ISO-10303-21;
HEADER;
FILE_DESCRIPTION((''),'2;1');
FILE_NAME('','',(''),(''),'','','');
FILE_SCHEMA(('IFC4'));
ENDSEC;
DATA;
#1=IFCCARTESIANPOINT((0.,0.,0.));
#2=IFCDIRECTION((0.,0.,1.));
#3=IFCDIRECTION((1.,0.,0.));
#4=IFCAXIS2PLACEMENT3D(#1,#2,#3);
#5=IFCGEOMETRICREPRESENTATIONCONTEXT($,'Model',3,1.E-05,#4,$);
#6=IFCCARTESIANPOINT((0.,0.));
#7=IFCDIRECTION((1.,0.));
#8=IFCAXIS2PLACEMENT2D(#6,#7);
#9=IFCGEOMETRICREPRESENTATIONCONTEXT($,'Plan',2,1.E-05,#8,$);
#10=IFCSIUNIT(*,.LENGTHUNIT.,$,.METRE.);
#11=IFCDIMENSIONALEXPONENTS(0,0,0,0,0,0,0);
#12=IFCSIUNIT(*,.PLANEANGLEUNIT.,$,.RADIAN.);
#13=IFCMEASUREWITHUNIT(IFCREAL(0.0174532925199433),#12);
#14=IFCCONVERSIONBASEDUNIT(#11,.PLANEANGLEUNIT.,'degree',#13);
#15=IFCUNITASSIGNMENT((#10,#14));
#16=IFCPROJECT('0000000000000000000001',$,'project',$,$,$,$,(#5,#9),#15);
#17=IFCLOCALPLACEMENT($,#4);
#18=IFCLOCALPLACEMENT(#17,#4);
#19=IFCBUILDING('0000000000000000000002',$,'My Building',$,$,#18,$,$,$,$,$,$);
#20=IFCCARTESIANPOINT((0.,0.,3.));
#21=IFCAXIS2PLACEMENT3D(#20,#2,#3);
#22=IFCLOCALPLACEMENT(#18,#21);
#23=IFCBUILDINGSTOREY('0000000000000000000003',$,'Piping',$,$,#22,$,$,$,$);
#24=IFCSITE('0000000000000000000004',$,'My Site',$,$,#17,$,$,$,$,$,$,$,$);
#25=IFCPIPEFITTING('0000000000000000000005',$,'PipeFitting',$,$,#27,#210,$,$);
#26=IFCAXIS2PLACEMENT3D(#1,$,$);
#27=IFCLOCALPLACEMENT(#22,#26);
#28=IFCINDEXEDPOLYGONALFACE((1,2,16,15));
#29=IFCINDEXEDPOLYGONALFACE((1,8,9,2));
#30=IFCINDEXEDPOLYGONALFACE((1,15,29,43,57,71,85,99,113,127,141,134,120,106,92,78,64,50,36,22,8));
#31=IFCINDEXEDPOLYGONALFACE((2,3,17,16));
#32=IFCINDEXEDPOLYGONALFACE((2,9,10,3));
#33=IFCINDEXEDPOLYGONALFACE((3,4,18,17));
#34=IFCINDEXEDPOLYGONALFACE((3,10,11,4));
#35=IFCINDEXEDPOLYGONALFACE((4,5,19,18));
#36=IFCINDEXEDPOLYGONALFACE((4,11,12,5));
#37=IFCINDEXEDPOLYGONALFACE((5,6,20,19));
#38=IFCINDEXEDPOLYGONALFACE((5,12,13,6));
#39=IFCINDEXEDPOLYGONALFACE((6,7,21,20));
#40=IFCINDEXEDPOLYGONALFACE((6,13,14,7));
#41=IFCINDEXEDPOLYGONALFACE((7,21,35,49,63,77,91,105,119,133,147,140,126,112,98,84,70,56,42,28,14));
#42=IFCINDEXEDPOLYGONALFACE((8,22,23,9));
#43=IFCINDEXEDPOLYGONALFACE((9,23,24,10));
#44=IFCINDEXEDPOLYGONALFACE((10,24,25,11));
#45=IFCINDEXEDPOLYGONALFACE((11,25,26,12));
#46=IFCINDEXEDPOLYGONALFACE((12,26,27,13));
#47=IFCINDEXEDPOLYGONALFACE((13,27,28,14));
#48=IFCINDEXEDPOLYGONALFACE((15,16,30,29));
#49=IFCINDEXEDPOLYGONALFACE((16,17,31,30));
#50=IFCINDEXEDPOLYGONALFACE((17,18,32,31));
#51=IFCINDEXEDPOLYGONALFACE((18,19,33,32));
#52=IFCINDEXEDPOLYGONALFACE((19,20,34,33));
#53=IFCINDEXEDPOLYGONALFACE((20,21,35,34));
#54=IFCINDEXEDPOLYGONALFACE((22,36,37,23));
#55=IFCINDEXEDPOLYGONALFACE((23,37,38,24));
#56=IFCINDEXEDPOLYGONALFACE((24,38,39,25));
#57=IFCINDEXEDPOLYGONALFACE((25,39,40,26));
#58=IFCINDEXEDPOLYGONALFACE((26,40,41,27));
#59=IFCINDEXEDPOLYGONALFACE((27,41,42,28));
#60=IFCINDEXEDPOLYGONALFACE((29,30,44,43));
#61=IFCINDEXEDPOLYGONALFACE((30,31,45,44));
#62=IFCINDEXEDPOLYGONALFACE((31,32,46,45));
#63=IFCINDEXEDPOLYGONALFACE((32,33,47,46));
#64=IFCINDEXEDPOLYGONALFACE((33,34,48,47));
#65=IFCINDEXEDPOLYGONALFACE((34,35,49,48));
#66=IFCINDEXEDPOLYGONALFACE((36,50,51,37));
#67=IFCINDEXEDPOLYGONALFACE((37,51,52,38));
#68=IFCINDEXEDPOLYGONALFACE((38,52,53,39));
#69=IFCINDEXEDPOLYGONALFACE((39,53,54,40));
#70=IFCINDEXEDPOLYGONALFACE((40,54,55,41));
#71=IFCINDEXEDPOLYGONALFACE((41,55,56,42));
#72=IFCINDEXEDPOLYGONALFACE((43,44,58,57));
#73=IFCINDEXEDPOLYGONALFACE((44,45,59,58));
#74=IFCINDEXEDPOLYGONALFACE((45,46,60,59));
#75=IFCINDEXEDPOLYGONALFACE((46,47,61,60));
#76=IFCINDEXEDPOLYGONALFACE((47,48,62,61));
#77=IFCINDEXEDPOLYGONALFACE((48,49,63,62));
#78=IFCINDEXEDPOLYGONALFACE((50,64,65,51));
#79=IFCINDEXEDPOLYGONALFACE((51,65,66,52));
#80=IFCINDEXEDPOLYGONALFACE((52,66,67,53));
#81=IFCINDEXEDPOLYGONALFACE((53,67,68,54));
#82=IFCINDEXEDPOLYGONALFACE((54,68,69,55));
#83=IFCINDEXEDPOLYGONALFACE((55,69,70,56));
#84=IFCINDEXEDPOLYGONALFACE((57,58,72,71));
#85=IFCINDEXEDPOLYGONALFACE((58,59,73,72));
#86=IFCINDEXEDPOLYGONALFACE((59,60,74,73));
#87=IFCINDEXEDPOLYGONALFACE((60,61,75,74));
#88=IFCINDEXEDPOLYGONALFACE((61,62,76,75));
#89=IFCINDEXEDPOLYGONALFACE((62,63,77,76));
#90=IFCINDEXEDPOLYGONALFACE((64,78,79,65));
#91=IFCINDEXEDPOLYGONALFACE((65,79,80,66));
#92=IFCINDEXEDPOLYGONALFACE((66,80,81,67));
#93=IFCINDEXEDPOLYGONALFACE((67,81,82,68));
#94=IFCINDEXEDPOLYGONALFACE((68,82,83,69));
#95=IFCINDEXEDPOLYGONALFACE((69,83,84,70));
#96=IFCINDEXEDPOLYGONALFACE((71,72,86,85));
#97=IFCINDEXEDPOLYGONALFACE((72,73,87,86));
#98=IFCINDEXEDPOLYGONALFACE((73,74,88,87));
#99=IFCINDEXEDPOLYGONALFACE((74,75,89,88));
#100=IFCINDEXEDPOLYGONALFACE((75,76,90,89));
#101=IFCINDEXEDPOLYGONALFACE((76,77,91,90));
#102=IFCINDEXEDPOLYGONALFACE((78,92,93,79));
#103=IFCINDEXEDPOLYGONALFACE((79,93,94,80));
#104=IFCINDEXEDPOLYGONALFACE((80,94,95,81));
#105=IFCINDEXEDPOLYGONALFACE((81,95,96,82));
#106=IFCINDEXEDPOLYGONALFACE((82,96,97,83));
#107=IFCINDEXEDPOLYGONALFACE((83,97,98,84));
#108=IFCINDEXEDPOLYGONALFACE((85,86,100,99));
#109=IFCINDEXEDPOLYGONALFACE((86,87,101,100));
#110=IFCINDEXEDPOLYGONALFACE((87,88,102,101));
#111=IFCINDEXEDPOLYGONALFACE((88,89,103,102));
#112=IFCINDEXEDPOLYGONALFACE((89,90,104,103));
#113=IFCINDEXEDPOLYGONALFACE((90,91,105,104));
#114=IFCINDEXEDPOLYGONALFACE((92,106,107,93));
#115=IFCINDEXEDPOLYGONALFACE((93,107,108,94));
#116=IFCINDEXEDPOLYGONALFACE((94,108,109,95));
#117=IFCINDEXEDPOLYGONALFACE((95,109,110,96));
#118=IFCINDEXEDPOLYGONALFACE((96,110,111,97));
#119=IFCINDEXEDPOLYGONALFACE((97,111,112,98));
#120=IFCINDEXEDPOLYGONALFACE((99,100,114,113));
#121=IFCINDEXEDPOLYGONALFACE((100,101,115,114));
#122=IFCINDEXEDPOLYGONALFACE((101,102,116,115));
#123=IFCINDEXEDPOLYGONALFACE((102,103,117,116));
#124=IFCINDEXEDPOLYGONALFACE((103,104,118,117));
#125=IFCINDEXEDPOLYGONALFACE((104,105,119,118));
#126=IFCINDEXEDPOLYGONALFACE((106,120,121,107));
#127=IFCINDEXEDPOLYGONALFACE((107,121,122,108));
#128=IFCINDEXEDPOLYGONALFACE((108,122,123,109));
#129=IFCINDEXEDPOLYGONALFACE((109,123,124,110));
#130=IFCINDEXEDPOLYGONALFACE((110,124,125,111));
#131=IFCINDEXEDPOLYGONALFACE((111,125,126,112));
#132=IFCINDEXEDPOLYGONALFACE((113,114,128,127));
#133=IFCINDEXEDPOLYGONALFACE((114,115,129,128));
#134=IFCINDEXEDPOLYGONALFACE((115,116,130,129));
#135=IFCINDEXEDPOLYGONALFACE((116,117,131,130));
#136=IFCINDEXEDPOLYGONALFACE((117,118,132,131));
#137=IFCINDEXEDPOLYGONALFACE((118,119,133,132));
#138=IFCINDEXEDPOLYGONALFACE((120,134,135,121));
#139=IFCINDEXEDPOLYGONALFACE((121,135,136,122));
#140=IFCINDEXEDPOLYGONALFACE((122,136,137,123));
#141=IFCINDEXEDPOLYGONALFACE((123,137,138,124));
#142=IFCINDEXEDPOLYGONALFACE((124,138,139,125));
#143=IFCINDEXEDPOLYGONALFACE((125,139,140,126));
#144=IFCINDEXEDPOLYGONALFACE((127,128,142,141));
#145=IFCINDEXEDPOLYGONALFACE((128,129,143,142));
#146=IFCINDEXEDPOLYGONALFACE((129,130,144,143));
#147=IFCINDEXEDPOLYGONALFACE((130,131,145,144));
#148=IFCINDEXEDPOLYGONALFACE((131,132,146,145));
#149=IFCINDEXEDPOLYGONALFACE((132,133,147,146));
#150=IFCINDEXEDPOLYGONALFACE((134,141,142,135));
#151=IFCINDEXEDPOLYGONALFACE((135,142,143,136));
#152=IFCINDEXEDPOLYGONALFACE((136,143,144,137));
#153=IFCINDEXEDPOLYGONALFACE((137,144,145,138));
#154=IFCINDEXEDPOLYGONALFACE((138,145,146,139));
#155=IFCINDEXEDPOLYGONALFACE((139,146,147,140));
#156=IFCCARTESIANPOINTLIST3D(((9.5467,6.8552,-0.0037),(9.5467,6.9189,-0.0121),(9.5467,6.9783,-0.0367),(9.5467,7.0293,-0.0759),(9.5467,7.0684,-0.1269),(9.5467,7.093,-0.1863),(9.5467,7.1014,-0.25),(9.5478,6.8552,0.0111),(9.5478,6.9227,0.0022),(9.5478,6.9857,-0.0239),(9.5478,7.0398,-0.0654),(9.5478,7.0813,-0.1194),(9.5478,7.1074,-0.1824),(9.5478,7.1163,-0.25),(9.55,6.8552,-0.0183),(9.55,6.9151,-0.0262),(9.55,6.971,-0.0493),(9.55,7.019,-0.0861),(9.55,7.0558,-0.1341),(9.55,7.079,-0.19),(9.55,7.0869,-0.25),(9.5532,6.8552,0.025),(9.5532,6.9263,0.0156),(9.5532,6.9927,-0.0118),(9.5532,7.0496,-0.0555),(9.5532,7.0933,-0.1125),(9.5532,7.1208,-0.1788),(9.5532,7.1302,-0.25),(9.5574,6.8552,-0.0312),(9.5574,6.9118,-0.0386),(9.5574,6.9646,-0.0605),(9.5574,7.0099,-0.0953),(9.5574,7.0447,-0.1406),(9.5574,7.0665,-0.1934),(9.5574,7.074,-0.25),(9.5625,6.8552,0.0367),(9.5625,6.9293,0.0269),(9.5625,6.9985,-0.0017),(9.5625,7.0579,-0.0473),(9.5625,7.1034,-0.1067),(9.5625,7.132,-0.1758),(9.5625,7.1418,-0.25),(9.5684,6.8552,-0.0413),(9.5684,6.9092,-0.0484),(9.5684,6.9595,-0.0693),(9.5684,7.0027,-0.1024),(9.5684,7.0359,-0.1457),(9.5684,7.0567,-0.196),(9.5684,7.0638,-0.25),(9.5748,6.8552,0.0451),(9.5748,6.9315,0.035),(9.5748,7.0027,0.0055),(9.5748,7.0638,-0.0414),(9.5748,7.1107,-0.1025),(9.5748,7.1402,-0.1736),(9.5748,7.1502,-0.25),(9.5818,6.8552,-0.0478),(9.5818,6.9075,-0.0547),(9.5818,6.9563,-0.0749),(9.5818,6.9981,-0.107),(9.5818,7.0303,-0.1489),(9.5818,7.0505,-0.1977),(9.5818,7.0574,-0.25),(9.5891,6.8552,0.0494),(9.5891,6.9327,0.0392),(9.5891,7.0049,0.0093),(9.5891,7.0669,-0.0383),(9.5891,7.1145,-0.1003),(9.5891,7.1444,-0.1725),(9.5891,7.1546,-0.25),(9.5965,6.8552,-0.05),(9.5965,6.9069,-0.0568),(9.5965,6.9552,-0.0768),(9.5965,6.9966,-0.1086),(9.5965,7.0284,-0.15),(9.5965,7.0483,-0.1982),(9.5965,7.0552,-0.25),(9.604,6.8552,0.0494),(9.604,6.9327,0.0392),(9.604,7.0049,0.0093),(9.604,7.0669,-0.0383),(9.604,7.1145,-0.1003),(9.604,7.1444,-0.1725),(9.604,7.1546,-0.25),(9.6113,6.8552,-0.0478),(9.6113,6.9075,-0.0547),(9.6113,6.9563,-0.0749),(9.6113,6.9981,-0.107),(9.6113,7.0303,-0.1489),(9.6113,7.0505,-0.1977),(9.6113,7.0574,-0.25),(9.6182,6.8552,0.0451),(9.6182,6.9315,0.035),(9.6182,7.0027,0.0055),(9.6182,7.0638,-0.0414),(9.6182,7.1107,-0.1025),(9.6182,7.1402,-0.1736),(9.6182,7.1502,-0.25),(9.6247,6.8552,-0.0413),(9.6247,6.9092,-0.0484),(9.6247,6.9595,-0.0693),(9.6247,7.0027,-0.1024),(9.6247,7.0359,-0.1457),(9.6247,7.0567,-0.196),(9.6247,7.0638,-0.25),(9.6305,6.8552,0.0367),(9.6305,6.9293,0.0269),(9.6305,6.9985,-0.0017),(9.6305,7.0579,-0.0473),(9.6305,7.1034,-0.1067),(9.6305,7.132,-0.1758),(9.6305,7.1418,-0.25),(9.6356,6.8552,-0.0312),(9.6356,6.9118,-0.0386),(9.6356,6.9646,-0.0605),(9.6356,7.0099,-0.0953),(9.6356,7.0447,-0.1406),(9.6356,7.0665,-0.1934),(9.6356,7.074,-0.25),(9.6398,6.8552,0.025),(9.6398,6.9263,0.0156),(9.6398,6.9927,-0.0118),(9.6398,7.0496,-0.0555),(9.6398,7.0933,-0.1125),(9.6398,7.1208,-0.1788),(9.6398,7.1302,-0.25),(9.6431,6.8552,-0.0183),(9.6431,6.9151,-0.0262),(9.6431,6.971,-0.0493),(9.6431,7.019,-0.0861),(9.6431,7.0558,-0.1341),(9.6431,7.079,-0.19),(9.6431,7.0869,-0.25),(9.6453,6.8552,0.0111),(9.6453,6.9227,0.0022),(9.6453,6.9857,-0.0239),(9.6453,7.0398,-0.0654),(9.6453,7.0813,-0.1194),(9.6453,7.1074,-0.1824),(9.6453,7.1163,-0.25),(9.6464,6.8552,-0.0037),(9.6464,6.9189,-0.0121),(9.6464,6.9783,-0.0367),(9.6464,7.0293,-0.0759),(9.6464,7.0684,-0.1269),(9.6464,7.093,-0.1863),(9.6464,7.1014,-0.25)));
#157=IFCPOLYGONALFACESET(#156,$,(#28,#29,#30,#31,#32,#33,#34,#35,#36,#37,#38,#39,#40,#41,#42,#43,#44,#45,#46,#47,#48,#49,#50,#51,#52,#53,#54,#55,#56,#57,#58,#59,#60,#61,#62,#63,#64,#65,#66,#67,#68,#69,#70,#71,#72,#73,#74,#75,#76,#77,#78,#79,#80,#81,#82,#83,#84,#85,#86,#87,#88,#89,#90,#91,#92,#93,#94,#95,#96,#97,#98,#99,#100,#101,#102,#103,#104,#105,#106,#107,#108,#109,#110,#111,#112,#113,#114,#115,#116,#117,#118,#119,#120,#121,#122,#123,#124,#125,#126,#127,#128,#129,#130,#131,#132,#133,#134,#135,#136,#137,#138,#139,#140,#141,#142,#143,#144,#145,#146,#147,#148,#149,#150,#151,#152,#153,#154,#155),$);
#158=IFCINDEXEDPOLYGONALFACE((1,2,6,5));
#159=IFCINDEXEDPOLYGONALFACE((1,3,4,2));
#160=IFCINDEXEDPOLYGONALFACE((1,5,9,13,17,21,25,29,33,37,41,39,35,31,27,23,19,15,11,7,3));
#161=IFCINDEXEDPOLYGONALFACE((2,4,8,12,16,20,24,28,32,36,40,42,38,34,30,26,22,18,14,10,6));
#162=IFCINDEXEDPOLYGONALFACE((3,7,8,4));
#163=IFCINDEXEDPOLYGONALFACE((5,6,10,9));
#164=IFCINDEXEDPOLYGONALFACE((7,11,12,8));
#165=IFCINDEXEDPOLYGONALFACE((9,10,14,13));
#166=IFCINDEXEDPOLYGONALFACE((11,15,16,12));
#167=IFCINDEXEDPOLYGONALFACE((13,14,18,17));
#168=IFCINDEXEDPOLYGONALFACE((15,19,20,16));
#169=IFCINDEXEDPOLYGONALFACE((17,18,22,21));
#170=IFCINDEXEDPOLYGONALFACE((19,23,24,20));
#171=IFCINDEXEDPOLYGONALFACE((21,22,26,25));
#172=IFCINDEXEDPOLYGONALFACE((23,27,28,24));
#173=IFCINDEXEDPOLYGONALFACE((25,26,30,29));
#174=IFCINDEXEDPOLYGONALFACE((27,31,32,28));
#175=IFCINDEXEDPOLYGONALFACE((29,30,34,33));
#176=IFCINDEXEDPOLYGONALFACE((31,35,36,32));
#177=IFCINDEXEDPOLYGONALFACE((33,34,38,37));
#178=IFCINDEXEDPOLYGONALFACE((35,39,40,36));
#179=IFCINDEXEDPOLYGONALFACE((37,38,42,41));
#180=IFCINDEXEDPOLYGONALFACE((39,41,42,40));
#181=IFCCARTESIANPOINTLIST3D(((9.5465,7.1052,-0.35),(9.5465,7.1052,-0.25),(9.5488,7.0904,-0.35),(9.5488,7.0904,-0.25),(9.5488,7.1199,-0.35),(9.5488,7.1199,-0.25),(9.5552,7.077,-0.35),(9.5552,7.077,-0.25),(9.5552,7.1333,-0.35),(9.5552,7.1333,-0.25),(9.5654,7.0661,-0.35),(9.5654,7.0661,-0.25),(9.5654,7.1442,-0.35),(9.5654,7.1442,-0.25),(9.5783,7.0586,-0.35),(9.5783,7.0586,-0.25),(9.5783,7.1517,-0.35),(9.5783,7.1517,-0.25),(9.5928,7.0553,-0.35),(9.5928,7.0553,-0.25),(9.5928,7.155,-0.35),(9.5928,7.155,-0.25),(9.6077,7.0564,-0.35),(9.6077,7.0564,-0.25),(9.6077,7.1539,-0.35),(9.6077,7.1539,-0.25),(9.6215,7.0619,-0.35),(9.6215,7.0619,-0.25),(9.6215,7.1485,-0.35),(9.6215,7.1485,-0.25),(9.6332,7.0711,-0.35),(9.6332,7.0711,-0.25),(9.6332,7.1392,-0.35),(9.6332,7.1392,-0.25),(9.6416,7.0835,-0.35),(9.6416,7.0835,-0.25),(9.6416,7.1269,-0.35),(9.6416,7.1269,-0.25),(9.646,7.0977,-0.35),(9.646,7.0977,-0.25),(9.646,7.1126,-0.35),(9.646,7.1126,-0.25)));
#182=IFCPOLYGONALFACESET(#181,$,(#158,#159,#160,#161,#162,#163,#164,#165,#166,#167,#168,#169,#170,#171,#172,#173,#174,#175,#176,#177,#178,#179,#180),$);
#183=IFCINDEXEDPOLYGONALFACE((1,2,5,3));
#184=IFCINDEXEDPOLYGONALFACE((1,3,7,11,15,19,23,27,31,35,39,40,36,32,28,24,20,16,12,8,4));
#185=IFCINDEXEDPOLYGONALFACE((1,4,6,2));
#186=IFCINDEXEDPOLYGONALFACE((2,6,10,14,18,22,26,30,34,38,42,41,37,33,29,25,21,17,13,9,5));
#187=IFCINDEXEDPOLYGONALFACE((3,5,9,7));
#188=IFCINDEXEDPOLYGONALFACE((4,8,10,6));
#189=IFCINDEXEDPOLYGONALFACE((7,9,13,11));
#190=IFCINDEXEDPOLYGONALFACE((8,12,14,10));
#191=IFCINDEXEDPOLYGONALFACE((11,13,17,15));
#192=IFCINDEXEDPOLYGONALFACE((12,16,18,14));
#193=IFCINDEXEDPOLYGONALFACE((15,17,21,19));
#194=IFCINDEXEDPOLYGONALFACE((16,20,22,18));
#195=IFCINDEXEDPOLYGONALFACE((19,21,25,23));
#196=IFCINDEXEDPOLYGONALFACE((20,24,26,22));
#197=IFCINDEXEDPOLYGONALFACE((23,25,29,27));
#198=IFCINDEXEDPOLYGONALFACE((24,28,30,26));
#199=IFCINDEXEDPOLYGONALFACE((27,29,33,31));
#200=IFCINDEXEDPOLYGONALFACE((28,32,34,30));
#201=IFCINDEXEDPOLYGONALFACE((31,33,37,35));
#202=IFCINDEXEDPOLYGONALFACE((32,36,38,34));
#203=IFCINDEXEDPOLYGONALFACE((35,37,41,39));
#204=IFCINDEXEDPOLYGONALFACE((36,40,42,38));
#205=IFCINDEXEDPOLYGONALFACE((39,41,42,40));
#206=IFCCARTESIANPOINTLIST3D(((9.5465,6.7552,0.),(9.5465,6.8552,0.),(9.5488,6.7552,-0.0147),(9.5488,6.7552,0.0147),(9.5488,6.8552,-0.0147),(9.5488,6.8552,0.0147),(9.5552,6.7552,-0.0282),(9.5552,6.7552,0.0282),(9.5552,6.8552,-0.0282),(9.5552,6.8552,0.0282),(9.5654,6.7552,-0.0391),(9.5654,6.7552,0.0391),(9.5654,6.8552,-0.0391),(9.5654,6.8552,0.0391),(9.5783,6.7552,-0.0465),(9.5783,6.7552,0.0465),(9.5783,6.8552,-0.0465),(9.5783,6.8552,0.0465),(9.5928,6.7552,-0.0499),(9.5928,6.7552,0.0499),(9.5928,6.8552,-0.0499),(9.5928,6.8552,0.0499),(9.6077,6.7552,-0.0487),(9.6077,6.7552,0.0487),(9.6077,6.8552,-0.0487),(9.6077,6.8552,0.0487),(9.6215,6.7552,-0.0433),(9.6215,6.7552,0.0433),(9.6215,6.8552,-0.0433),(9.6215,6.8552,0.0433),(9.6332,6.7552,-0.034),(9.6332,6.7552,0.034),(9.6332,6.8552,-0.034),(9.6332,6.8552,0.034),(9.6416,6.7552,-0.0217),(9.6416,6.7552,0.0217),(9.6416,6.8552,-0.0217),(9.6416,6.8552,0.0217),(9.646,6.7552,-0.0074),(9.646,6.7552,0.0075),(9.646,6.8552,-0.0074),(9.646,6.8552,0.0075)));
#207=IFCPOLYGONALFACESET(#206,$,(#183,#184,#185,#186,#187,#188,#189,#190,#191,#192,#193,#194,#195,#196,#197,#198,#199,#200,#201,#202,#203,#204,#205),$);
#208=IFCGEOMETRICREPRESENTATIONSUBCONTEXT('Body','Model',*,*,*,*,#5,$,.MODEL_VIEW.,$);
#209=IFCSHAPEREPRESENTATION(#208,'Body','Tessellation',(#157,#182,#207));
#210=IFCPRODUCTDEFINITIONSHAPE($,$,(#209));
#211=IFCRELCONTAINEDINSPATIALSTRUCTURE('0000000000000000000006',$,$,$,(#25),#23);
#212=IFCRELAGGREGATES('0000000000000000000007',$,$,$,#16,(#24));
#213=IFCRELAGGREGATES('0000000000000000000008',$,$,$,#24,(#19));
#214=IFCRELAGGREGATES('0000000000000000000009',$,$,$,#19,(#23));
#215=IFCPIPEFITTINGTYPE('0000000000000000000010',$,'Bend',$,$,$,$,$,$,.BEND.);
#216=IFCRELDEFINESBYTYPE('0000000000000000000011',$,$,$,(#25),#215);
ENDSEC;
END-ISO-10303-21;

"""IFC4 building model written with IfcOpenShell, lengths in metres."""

from ifc_helpers import new_model, entity, si_unit, converted_unit, frame, origin_with_axes, origin_2d_with_axis, place, context, subcontext, project, spatial, circle, extrude, source, transform, mapped, type_object, type_shapes, element, save


model = new_model("IFC4")

# Units and contexts
model_context = context("Model", 3, precision=1e-05, world=origin_with_axes())
plan_context = context("Plan", 2, precision=1e-05, world=origin_2d_with_axis())
body_context = subcontext(model_context, "Body", "Model", "MODEL_VIEW")
ifc_project = project(units=[si_unit("LENGTHUNIT", "METRE"), converted_unit("PLANEANGLEUNIT", "degree", entity("IfcReal", 0.0174532925199433), si_unit("PLANEANGLEUNIT", "RADIAN"), dimensions=[0, 0, 0, 0, 0, 0, 0])], contexts=[model_context, plan_context])

# Site, building, storey
site_placement = place(None, origin_with_axes())
site = spatial("IfcSite", under=ifc_project, at=site_placement, Name="My Site")
building_placement = place(site_placement, origin_with_axes())
building = spatial("IfcBuilding", under=site, at=building_placement, Name="My Building")
storey_placement = place(building_placement, frame((0.0, 0.0, 3.0), z_axis=(0.0, 0.0, 1.0), x_axis=(1.0, 0.0, 0.0)))
storey = spatial("IfcBuildingStorey", under=building, at=storey_placement, Name="Piping")

# Shared definitions
pipe_fitting_type = type_object("IfcPipeFittingType", Name="Bend", PredefinedType="BEND")
shared_shape = source(origin_with_axes(), body_context, "Body", "SolidModel", [
    entity("IfcSweptDiskSolid", entity("IfcIndexedPolyCurve", entity("IfcCartesianPointList3D", [[0.0, 0.0, -0.1], [0.0, -0.0732, -0.2768], [0.0, -0.25, -0.35]]), [entity("IfcArcIndex", [1, 2, 3])]), 0.05),
    extrude(circle(Radius=0.05), origin_with_axes(), (0.0, 0.0, -1.0), 0.1),
    extrude(circle(Radius=0.05), frame((0.0, -0.25, -0.35), z_axis=(0.0, -1.0, 0.0), x_axis=(1.0, 0.0, 0.0)), (0.0, 0.0, 1.0), 0.1),
])
type_shapes(pipe_fitting_type, [shared_shape])

# Pipe fitting
for number, where, z_axis, x_axis, name in (
    (1, (9.5965, 7.1052, -0.35), (0.0, 0.0, -1.0), (-1.0, 0.0, 0.0), "PipeFitting"),
):
    element("IfcPipeFitting", number, at=place(storey_placement, frame(where, z_axis=z_axis, x_axis=x_axis)), inside=storey, type_object=pipe_fitting_type, Name=name, context=body_context, shape_type="MappedRepresentation", body=[
        mapped(shared_shape, transform((0.0, 0.0, 0.0), x_axis=(1.0, 0.0, 0.0), y_axis=(0.0, 1.0, 0.0), z_axis=(0.0, 0.0, 1.0), scale=1.0)),
    ])

save(model, "model.ifc")
